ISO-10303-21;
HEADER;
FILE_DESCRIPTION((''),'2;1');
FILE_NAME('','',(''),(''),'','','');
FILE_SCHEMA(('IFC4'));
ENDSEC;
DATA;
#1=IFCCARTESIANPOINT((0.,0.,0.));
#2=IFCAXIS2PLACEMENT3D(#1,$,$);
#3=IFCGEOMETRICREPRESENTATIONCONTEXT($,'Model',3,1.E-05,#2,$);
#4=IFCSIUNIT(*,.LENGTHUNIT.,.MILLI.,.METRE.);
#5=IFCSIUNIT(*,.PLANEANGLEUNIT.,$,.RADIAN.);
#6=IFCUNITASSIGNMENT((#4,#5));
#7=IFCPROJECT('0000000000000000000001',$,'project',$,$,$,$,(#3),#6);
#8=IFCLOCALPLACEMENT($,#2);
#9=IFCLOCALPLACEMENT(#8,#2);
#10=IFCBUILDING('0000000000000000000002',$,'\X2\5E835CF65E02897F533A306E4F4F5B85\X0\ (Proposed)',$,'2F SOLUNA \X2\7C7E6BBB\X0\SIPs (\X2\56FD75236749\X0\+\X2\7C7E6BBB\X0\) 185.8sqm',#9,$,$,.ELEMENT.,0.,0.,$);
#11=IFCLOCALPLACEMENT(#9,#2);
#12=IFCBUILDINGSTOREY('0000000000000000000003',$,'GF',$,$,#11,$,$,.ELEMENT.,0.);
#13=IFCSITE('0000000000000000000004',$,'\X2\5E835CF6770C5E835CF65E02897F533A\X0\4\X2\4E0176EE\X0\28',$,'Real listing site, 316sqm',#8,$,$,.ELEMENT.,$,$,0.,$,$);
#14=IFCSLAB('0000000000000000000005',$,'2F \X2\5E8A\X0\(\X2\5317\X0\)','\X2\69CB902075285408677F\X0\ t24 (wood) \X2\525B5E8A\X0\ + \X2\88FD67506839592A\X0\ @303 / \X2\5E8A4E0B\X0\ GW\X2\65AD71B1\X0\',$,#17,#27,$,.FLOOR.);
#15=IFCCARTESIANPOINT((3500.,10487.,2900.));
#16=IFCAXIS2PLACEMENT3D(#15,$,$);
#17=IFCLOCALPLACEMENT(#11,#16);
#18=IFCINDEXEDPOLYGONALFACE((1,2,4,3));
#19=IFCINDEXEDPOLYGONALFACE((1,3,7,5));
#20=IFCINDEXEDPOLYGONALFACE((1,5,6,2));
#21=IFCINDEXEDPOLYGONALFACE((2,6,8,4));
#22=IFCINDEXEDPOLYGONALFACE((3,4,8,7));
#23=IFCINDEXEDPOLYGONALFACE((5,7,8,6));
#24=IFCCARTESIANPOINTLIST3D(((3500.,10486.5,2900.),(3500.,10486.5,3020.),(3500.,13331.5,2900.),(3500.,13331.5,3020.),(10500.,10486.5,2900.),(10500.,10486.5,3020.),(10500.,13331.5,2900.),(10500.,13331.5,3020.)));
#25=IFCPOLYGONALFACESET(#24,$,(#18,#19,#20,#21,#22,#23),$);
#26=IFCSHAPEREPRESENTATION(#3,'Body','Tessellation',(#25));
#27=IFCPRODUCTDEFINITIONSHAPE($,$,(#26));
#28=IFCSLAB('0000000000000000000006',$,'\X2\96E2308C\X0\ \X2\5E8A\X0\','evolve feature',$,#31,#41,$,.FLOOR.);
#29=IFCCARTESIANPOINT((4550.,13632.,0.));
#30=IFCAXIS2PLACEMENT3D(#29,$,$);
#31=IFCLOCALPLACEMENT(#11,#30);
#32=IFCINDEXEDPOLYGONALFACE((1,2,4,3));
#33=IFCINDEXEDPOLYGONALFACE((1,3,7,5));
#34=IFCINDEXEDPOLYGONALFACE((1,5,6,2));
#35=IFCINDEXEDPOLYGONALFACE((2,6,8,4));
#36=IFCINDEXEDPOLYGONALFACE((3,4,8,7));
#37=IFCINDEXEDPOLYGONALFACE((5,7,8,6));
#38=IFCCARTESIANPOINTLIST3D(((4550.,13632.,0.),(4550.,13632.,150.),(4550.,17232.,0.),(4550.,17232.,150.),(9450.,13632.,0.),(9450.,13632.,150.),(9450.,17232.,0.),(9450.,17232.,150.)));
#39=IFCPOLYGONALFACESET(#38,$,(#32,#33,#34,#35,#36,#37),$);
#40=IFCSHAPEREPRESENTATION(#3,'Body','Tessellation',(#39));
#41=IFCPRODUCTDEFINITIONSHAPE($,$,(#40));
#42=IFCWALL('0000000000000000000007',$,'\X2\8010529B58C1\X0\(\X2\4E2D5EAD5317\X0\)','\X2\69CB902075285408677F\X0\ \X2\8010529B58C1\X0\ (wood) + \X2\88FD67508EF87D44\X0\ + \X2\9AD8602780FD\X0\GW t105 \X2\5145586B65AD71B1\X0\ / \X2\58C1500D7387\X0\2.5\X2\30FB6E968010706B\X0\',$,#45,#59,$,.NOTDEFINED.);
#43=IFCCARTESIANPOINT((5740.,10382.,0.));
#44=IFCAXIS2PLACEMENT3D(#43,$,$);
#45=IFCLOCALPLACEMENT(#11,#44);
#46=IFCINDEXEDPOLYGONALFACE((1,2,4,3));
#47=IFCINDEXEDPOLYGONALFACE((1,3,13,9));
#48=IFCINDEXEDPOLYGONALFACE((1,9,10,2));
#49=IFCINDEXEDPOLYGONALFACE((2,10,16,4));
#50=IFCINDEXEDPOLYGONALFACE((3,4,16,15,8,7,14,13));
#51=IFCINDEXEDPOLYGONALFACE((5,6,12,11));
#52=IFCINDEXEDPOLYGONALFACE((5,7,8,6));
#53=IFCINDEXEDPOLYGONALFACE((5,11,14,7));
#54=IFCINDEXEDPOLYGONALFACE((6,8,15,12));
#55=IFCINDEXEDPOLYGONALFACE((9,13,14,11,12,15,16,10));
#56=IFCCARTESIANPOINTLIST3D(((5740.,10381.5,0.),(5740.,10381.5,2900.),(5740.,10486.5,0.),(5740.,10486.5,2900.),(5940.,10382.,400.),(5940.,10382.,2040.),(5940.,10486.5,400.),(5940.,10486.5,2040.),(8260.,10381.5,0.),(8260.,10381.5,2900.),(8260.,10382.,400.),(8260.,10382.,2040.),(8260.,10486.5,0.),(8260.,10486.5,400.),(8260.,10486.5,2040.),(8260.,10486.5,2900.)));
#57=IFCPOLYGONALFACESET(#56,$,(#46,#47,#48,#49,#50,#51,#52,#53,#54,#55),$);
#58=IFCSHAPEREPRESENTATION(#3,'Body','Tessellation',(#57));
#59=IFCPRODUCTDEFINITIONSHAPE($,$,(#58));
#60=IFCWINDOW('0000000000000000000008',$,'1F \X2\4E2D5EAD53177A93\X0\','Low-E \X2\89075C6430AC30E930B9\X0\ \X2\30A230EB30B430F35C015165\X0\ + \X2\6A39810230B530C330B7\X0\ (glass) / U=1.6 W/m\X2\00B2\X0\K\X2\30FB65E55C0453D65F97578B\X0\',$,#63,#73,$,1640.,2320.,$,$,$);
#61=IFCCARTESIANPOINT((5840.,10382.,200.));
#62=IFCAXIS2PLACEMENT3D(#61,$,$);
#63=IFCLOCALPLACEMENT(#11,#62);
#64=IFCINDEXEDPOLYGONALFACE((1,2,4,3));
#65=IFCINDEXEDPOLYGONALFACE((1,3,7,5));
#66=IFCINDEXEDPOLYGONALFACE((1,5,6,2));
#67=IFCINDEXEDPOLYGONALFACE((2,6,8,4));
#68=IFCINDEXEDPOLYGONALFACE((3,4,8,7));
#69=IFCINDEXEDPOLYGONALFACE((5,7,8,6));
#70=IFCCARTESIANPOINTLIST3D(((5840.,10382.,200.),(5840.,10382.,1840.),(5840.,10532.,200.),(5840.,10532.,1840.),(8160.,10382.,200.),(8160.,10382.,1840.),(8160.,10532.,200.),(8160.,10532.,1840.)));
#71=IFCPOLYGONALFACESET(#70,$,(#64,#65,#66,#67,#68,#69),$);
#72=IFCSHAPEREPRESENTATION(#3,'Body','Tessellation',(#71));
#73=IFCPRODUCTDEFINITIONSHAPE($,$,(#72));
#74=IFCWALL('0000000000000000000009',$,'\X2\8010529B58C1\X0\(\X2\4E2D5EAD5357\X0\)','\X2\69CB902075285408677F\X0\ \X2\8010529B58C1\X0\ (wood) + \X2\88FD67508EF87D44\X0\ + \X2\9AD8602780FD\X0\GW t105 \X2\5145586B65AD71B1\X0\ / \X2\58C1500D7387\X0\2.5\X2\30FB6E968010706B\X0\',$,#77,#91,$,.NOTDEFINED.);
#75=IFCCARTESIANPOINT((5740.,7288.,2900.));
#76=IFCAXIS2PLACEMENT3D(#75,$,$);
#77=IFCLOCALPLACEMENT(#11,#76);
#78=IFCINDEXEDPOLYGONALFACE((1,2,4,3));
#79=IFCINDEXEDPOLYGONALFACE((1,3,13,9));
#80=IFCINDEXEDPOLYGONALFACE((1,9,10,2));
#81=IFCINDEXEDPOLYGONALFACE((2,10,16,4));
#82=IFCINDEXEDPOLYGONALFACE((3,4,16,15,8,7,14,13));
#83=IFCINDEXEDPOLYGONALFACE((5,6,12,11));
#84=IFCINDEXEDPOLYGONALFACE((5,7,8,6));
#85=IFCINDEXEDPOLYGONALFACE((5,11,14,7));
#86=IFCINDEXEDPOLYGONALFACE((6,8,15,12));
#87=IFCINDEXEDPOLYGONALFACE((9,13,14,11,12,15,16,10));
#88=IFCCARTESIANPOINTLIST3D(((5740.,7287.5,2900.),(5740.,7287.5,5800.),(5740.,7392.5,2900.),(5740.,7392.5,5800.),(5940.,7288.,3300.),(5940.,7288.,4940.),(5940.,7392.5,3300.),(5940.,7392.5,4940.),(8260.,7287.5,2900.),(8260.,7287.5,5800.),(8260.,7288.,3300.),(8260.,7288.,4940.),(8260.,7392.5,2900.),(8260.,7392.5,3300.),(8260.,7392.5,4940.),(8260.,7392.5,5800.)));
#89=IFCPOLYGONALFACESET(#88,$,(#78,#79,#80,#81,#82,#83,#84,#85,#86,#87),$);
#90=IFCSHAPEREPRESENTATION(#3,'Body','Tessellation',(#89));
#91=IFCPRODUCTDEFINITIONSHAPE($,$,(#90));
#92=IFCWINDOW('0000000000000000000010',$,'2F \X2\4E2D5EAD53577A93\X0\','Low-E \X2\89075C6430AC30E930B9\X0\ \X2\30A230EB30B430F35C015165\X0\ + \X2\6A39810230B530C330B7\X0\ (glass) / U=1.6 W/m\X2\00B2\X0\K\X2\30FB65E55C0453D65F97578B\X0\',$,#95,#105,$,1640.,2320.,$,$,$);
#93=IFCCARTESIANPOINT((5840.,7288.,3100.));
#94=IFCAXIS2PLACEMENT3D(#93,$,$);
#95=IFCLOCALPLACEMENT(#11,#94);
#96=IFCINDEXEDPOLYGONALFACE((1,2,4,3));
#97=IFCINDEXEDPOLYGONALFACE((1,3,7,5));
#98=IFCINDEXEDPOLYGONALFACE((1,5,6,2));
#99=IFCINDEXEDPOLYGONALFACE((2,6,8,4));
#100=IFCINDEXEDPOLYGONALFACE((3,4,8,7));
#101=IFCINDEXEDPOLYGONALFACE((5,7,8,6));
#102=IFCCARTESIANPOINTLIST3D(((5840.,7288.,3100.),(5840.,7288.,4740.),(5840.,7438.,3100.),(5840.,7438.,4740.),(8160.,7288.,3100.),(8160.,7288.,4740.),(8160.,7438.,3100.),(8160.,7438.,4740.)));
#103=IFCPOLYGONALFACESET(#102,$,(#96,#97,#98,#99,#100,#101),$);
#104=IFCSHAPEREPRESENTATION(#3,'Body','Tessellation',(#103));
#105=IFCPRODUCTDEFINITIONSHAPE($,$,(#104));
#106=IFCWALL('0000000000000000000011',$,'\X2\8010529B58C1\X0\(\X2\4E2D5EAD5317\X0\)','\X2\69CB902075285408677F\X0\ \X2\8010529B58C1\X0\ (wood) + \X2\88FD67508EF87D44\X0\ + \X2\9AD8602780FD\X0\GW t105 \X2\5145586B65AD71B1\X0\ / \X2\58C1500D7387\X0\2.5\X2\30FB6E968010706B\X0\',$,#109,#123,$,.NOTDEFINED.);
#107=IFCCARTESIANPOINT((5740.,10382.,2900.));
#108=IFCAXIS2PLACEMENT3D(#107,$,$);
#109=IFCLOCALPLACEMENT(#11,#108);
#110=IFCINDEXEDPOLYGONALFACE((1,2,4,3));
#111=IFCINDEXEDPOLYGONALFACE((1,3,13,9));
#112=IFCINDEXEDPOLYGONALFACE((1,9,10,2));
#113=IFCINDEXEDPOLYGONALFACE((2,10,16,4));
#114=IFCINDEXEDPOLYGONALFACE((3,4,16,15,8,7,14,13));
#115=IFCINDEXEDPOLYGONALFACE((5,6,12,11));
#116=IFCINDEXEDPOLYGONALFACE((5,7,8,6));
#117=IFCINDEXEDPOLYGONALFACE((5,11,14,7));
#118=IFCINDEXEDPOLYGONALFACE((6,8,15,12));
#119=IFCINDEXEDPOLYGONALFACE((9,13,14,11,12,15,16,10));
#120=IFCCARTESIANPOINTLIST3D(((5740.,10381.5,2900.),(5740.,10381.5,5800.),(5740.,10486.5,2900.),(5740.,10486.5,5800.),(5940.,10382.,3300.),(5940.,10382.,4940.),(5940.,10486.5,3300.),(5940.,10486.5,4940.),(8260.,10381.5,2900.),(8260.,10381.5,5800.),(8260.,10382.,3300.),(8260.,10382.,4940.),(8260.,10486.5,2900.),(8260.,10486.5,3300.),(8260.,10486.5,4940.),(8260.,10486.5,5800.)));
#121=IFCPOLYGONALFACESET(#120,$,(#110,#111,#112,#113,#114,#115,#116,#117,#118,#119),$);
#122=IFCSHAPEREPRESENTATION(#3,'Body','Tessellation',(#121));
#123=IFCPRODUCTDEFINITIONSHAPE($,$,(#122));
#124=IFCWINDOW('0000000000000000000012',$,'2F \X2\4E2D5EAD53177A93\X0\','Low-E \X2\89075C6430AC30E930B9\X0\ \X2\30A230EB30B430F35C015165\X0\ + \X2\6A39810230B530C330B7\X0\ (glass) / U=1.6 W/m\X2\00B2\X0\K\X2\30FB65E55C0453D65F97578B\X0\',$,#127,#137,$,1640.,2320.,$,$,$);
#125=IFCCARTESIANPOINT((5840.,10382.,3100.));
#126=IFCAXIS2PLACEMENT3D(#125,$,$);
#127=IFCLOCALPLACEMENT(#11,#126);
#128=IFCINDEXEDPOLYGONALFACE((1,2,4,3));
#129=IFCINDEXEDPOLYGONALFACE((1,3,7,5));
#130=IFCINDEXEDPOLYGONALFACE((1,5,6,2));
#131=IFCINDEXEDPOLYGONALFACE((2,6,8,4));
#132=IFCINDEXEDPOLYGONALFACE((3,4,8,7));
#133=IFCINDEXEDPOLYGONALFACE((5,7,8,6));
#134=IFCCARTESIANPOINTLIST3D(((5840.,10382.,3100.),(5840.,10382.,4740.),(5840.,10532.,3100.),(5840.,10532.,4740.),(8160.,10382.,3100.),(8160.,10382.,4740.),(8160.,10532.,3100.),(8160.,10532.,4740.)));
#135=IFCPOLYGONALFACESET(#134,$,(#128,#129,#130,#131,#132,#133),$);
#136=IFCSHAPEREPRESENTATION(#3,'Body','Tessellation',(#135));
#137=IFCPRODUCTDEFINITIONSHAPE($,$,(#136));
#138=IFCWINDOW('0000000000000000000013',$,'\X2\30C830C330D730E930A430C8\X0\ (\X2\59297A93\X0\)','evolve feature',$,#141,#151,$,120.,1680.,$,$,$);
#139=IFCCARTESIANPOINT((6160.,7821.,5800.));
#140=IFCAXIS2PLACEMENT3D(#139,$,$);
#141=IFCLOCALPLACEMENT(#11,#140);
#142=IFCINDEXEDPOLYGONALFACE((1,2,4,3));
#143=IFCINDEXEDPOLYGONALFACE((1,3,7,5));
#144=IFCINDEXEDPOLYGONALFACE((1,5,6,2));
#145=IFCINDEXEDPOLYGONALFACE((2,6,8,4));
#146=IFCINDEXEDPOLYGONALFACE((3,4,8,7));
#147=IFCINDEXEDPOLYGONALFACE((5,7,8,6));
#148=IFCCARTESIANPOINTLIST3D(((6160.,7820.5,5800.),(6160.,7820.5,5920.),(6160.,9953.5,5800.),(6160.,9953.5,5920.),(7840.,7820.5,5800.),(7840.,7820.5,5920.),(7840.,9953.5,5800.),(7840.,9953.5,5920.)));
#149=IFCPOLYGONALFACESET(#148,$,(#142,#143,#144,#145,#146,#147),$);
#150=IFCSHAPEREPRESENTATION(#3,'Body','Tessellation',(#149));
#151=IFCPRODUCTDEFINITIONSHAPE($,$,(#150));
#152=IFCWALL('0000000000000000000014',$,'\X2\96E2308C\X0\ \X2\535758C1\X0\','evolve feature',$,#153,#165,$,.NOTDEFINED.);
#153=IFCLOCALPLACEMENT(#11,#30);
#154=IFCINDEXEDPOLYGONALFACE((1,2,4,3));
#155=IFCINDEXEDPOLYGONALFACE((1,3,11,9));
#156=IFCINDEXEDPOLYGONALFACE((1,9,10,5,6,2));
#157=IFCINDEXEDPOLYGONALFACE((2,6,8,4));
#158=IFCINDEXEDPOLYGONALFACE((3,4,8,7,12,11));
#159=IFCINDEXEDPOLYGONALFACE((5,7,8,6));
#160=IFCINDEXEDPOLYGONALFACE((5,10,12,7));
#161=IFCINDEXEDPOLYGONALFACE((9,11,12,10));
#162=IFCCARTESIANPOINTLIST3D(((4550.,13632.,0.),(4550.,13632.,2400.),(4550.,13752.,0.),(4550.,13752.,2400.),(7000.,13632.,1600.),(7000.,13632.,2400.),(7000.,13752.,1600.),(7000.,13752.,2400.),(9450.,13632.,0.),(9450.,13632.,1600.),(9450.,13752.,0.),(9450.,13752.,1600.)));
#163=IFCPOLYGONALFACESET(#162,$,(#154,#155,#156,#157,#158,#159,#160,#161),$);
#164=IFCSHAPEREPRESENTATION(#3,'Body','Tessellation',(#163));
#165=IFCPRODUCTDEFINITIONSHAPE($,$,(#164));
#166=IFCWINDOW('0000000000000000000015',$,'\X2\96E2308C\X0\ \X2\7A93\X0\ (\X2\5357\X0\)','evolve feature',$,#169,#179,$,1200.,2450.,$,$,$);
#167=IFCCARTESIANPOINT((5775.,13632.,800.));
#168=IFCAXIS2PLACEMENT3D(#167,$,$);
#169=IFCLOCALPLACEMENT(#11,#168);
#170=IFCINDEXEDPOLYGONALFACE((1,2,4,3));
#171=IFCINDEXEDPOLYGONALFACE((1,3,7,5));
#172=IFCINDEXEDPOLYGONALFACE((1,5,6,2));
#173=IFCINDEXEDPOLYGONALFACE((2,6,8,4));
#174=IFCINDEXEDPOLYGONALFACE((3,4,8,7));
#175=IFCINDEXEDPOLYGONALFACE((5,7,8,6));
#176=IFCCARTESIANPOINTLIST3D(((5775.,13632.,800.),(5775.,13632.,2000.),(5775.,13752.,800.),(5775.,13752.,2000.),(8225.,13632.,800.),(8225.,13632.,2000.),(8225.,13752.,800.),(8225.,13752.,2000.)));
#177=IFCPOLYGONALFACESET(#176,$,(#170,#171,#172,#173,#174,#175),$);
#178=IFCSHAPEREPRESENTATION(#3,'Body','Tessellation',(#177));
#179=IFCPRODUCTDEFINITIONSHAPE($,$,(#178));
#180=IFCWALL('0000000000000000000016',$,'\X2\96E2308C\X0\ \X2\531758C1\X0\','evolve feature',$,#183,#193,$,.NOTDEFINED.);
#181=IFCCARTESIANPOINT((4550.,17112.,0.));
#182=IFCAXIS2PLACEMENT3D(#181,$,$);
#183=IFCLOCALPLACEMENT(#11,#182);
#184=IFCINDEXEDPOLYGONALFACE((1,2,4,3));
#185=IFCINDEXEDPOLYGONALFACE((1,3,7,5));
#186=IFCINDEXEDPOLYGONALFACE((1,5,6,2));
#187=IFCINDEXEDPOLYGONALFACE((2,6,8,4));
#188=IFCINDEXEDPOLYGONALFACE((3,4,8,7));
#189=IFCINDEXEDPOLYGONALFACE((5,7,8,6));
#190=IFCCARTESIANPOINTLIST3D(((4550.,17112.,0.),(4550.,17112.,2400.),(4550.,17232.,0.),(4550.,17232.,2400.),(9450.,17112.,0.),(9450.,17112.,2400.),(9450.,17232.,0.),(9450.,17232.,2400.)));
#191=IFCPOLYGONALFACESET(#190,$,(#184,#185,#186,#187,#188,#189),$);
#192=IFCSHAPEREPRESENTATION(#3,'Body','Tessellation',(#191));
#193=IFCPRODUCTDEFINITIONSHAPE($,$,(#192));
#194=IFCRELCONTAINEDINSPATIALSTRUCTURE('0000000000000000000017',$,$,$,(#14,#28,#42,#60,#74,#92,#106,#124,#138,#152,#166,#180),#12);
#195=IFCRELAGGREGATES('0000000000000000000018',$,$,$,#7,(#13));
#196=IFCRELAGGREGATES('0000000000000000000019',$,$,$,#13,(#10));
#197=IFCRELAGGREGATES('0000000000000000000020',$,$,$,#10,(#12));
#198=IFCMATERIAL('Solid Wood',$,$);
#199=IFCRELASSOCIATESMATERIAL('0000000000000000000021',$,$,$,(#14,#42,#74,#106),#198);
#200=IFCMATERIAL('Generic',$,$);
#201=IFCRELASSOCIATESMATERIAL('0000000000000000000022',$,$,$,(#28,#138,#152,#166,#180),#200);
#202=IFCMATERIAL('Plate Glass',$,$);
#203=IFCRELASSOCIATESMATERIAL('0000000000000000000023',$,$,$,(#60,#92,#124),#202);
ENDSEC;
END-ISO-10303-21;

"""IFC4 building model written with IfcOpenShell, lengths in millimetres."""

from ifc_helpers import new_model, si_unit, frame, frame_2d, origin, place, context, project, spatial, rectangle, extrude, material, element, fill, save


model = new_model("IFC4")

# Units and contexts
model_context = context("Model", 3, precision=1e-05, world=origin())
ifc_project = project(units=[si_unit("LENGTHUNIT", "METRE", prefix="MILLI"), si_unit("PLANEANGLEUNIT", "RADIAN")], contexts=[model_context])

# Site, building, storey
site_placement = place(None, origin())
site = spatial("IfcSite", under=ifc_project, at=site_placement, Name="広島県広島市西区4丁目28", ObjectType="Real listing site, 316sqm", CompositionType="ELEMENT", RefElevation=0.0)
building_placement = place(site_placement, origin())
building = spatial("IfcBuilding", under=site, at=building_placement, Name="広島市西区の住宅 (Proposed)", ObjectType="2F SOLUNA 籾殻SIPs (国産杉+籾殻) 185.8sqm", CompositionType="ELEMENT", ElevationOfRefHeight=0.0, ElevationOfTerrain=0.0)
storey_placement = place(building_placement, origin())
storey = spatial("IfcBuildingStorey", under=building, at=storey_placement, Name="GF", CompositionType="ELEMENT", Elevation=0.0)

# Slabs
ifc_material_1 = material(Name="Solid Wood")
slab_1_placement = place(storey_placement, frame((3500.0, 10487.0, 2900.0)))
element("IfcSlab", 1, at=slab_1_placement, inside=storey, material=ifc_material_1, Name="2F 床(北)", Description="構造用合板 t24 (wood) 剛床 + 製材根太 @303 / 床下 GW断熱", PredefinedType="FLOOR", context=model_context, shape_type="SweptSolid", body=[
    extrude(rectangle(XDim=7000.0, YDim=2845.0, at=frame_2d((3500.0, 1422.0))), frame((3500.0, 10487.0, 2900.0)), (0.0, 0.0, 1.0), 120.0),
])
ifc_material_2 = material(Name="Generic")
slab_2_placement = place(storey_placement, frame((4550.0, 13632.0, 0.0)))
element("IfcSlab", 2, at=slab_2_placement, inside=storey, material=ifc_material_2, Name="離れ 床", Description="evolve feature", PredefinedType="FLOOR", context=model_context, shape_type="SweptSolid", body=[
    extrude(rectangle(XDim=4900.0, YDim=3600.0, at=frame_2d((2450.0, 1800.0))), frame((4550.0, 13632.0, 0.0)), (0.0, 0.0, 1.0), 150.0),
])

# Wall, opening, window
wall_1_placement = place(storey_placement, frame((5740.0, 10382.0, 0.0)))
wall_1 = element("IfcWall", 3, at=wall_1_placement, inside=storey, material=ifc_material_1, Name="耐力壁(中庭北)", Description="構造用合板 耐力壁 (wood) + 製材軸組 + 高性能GW t105 充填断熱 / 壁倍率2.5・準耐火", PredefinedType="NOTDEFINED", context=model_context, shape_type="SweptSolid", body=[
    extrude(rectangle(XDim=2520.0, YDim=105.0, at=frame_2d((1260.0, 52.0))), frame((5740.0, 10382.0, 0.0)), (0.0, 0.0, 1.0), 2900.0),
])
opening_1_placement = place(storey_placement, frame((5840.0, 10382.0, 200.0)))
opening_1 = element("IfcOpeningElement", 4, at=opening_1_placement, cuts=wall_1, PredefinedType="NOTDEFINED", context=model_context, shape_type="SweptSolid", body=[
    extrude(rectangle(XDim=2320.0, YDim=150.0, at=frame_2d((1160.0, 75.0))), frame((5840.0, 10382.0, 200.0)), (0.0, 0.0, 1.0), 1640.0),
])
ifc_material_3 = material(Name="Plate Glass")
window_1_placement = place(storey_placement, frame((5840.0, 10382.0, 200.0)))
window_1 = element("IfcWindow", 5, at=window_1_placement, inside=storey, material=ifc_material_3, Name="1F 中庭北窓", Description="Low-E 複層ガラス アルゴン封入 + 樹脂サッシ (glass) / U=1.6 W/m²K・日射取得型", OverallHeight=1640.0, OverallWidth=2320.0, context=model_context, shape_type="SweptSolid", body=[
    extrude(rectangle(XDim=2320.0, YDim=150.0, at=frame_2d((1160.0, 75.0))), frame((5840.0, 10382.0, 200.0)), (0.0, 0.0, 1.0), 1640.0),
])
fill(opening_1, window_1)

# Walls, openings, windows
wall_2_placement = place(storey_placement, frame((5740.0, 7288.0, 2900.0)))
wall_2 = element("IfcWall", 6, at=wall_2_placement, inside=storey, material=ifc_material_1, Name="耐力壁(中庭南)", Description="構造用合板 耐力壁 (wood) + 製材軸組 + 高性能GW t105 充填断熱 / 壁倍率2.5・準耐火", PredefinedType="NOTDEFINED", context=model_context, shape_type="SweptSolid", body=[
    extrude(rectangle(XDim=2520.0, YDim=105.0, at=frame_2d((1260.0, 52.0))), frame((5740.0, 7288.0, 2900.0)), (0.0, 0.0, 1.0), 2900.0),
])
opening_2_placement = place(storey_placement, frame((5840.0, 7288.0, 3100.0)))
opening_2 = element("IfcOpeningElement", 7, at=opening_2_placement, cuts=wall_2, PredefinedType="NOTDEFINED", context=model_context, shape_type="SweptSolid", body=[
    extrude(rectangle(XDim=2320.0, YDim=150.0, at=frame_2d((1160.0, 75.0))), frame((5840.0, 7288.0, 3100.0)), (0.0, 0.0, 1.0), 1640.0),
])
window_2_placement = place(storey_placement, frame((5840.0, 7288.0, 3100.0)))
window_2 = element("IfcWindow", 8, at=window_2_placement, inside=storey, material=ifc_material_3, Name="2F 中庭南窓", Description="Low-E 複層ガラス アルゴン封入 + 樹脂サッシ (glass) / U=1.6 W/m²K・日射取得型", OverallHeight=1640.0, OverallWidth=2320.0, context=model_context, shape_type="SweptSolid", body=[
    extrude(rectangle(XDim=2320.0, YDim=150.0, at=frame_2d((1160.0, 75.0))), frame((5840.0, 7288.0, 3100.0)), (0.0, 0.0, 1.0), 1640.0),
])
fill(opening_2, window_2)
wall_3_placement = place(storey_placement, frame((5740.0, 10382.0, 2900.0)))
wall_3 = element("IfcWall", 9, at=wall_3_placement, inside=storey, material=ifc_material_1, Name="耐力壁(中庭北)", Description="構造用合板 耐力壁 (wood) + 製材軸組 + 高性能GW t105 充填断熱 / 壁倍率2.5・準耐火", PredefinedType="NOTDEFINED", context=model_context, shape_type="SweptSolid", body=[
    extrude(rectangle(XDim=2520.0, YDim=105.0, at=frame_2d((1260.0, 52.0))), frame((5740.0, 10382.0, 2900.0)), (0.0, 0.0, 1.0), 2900.0),
])
opening_3_placement = place(storey_placement, frame((5840.0, 10382.0, 3100.0)))
opening_3 = element("IfcOpeningElement", 10, at=opening_3_placement, cuts=wall_3, PredefinedType="NOTDEFINED", context=model_context, shape_type="SweptSolid", body=[
    extrude(rectangle(XDim=2320.0, YDim=150.0, at=frame_2d((1160.0, 75.0))), frame((5840.0, 10382.0, 3100.0)), (0.0, 0.0, 1.0), 1640.0),
])
window_3_placement = place(storey_placement, frame((5840.0, 10382.0, 3100.0)))
window_3 = element("IfcWindow", 11, at=window_3_placement, inside=storey, material=ifc_material_3, Name="2F 中庭北窓", Description="Low-E 複層ガラス アルゴン封入 + 樹脂サッシ (glass) / U=1.6 W/m²K・日射取得型", OverallHeight=1640.0, OverallWidth=2320.0, context=model_context, shape_type="SweptSolid", body=[
    extrude(rectangle(XDim=2320.0, YDim=150.0, at=frame_2d((1160.0, 75.0))), frame((5840.0, 10382.0, 3100.0)), (0.0, 0.0, 1.0), 1640.0),
])
fill(opening_3, window_3)

# Window
window_4_placement = place(storey_placement, frame((6160.0, 7821.0, 5800.0)))
element("IfcWindow", 12, at=window_4_placement, inside=storey, material=ifc_material_2, Name="トップライト (天窓)", Description="evolve feature", OverallHeight=120.0, OverallWidth=1680.0, context=model_context, shape_type="SweptSolid", body=[
    extrude(rectangle(XDim=1680.0, YDim=2133.0, at=frame_2d((840.0, 1066.0))), frame((6160.0, 7821.0, 5800.0)), (0.0, 0.0, 1.0), 120.0),
])

# Wall, opening, window
wall_4_placement = place(storey_placement, frame((4550.0, 13632.0, 0.0)))
wall_4 = element("IfcWall", 13, at=wall_4_placement, inside=storey, material=ifc_material_2, Name="離れ 南壁", Description="evolve feature", PredefinedType="NOTDEFINED", context=model_context, shape_type="SweptSolid", body=[
    extrude(rectangle(XDim=4900.0, YDim=120.0, at=frame_2d((2450.0, 60.0))), frame((4550.0, 13632.0, 0.0)), (0.0, 0.0, 1.0), 2400.0),
])
opening_4_placement = place(storey_placement, frame((5775.0, 13632.0, 800.0)))
opening_4 = element("IfcOpeningElement", 14, at=opening_4_placement, cuts=wall_4, PredefinedType="NOTDEFINED", context=model_context, shape_type="SweptSolid", body=[
    extrude(rectangle(XDim=2450.0, YDim=120.0, at=frame_2d((1225.0, 60.0))), frame((5775.0, 13632.0, 800.0)), (0.0, 0.0, 1.0), 1200.0),
])
window_5_placement = place(storey_placement, frame((5775.0, 13632.0, 800.0)))
window_5 = element("IfcWindow", 15, at=window_5_placement, inside=storey, material=ifc_material_2, Name="離れ 窓 (南)", Description="evolve feature", OverallHeight=1200.0, OverallWidth=2450.0, context=model_context, shape_type="SweptSolid", body=[
    extrude(rectangle(XDim=2450.0, YDim=120.0, at=frame_2d((1225.0, 60.0))), frame((5775.0, 13632.0, 800.0)), (0.0, 0.0, 1.0), 1200.0),
])
fill(opening_4, window_5)

# Wall
wall_5_placement = place(storey_placement, frame((4550.0, 17112.0, 0.0)))
element("IfcWall", 16, at=wall_5_placement, inside=storey, material=ifc_material_2, Name="離れ 北壁", Description="evolve feature", PredefinedType="NOTDEFINED", context=model_context, shape_type="SweptSolid", body=[
    extrude(rectangle(XDim=4900.0, YDim=120.0, at=frame_2d((2450.0, 60.0))), frame((4550.0, 17112.0, 0.0)), (0.0, 0.0, 1.0), 2400.0),
])

save(model, "model.ifc")
